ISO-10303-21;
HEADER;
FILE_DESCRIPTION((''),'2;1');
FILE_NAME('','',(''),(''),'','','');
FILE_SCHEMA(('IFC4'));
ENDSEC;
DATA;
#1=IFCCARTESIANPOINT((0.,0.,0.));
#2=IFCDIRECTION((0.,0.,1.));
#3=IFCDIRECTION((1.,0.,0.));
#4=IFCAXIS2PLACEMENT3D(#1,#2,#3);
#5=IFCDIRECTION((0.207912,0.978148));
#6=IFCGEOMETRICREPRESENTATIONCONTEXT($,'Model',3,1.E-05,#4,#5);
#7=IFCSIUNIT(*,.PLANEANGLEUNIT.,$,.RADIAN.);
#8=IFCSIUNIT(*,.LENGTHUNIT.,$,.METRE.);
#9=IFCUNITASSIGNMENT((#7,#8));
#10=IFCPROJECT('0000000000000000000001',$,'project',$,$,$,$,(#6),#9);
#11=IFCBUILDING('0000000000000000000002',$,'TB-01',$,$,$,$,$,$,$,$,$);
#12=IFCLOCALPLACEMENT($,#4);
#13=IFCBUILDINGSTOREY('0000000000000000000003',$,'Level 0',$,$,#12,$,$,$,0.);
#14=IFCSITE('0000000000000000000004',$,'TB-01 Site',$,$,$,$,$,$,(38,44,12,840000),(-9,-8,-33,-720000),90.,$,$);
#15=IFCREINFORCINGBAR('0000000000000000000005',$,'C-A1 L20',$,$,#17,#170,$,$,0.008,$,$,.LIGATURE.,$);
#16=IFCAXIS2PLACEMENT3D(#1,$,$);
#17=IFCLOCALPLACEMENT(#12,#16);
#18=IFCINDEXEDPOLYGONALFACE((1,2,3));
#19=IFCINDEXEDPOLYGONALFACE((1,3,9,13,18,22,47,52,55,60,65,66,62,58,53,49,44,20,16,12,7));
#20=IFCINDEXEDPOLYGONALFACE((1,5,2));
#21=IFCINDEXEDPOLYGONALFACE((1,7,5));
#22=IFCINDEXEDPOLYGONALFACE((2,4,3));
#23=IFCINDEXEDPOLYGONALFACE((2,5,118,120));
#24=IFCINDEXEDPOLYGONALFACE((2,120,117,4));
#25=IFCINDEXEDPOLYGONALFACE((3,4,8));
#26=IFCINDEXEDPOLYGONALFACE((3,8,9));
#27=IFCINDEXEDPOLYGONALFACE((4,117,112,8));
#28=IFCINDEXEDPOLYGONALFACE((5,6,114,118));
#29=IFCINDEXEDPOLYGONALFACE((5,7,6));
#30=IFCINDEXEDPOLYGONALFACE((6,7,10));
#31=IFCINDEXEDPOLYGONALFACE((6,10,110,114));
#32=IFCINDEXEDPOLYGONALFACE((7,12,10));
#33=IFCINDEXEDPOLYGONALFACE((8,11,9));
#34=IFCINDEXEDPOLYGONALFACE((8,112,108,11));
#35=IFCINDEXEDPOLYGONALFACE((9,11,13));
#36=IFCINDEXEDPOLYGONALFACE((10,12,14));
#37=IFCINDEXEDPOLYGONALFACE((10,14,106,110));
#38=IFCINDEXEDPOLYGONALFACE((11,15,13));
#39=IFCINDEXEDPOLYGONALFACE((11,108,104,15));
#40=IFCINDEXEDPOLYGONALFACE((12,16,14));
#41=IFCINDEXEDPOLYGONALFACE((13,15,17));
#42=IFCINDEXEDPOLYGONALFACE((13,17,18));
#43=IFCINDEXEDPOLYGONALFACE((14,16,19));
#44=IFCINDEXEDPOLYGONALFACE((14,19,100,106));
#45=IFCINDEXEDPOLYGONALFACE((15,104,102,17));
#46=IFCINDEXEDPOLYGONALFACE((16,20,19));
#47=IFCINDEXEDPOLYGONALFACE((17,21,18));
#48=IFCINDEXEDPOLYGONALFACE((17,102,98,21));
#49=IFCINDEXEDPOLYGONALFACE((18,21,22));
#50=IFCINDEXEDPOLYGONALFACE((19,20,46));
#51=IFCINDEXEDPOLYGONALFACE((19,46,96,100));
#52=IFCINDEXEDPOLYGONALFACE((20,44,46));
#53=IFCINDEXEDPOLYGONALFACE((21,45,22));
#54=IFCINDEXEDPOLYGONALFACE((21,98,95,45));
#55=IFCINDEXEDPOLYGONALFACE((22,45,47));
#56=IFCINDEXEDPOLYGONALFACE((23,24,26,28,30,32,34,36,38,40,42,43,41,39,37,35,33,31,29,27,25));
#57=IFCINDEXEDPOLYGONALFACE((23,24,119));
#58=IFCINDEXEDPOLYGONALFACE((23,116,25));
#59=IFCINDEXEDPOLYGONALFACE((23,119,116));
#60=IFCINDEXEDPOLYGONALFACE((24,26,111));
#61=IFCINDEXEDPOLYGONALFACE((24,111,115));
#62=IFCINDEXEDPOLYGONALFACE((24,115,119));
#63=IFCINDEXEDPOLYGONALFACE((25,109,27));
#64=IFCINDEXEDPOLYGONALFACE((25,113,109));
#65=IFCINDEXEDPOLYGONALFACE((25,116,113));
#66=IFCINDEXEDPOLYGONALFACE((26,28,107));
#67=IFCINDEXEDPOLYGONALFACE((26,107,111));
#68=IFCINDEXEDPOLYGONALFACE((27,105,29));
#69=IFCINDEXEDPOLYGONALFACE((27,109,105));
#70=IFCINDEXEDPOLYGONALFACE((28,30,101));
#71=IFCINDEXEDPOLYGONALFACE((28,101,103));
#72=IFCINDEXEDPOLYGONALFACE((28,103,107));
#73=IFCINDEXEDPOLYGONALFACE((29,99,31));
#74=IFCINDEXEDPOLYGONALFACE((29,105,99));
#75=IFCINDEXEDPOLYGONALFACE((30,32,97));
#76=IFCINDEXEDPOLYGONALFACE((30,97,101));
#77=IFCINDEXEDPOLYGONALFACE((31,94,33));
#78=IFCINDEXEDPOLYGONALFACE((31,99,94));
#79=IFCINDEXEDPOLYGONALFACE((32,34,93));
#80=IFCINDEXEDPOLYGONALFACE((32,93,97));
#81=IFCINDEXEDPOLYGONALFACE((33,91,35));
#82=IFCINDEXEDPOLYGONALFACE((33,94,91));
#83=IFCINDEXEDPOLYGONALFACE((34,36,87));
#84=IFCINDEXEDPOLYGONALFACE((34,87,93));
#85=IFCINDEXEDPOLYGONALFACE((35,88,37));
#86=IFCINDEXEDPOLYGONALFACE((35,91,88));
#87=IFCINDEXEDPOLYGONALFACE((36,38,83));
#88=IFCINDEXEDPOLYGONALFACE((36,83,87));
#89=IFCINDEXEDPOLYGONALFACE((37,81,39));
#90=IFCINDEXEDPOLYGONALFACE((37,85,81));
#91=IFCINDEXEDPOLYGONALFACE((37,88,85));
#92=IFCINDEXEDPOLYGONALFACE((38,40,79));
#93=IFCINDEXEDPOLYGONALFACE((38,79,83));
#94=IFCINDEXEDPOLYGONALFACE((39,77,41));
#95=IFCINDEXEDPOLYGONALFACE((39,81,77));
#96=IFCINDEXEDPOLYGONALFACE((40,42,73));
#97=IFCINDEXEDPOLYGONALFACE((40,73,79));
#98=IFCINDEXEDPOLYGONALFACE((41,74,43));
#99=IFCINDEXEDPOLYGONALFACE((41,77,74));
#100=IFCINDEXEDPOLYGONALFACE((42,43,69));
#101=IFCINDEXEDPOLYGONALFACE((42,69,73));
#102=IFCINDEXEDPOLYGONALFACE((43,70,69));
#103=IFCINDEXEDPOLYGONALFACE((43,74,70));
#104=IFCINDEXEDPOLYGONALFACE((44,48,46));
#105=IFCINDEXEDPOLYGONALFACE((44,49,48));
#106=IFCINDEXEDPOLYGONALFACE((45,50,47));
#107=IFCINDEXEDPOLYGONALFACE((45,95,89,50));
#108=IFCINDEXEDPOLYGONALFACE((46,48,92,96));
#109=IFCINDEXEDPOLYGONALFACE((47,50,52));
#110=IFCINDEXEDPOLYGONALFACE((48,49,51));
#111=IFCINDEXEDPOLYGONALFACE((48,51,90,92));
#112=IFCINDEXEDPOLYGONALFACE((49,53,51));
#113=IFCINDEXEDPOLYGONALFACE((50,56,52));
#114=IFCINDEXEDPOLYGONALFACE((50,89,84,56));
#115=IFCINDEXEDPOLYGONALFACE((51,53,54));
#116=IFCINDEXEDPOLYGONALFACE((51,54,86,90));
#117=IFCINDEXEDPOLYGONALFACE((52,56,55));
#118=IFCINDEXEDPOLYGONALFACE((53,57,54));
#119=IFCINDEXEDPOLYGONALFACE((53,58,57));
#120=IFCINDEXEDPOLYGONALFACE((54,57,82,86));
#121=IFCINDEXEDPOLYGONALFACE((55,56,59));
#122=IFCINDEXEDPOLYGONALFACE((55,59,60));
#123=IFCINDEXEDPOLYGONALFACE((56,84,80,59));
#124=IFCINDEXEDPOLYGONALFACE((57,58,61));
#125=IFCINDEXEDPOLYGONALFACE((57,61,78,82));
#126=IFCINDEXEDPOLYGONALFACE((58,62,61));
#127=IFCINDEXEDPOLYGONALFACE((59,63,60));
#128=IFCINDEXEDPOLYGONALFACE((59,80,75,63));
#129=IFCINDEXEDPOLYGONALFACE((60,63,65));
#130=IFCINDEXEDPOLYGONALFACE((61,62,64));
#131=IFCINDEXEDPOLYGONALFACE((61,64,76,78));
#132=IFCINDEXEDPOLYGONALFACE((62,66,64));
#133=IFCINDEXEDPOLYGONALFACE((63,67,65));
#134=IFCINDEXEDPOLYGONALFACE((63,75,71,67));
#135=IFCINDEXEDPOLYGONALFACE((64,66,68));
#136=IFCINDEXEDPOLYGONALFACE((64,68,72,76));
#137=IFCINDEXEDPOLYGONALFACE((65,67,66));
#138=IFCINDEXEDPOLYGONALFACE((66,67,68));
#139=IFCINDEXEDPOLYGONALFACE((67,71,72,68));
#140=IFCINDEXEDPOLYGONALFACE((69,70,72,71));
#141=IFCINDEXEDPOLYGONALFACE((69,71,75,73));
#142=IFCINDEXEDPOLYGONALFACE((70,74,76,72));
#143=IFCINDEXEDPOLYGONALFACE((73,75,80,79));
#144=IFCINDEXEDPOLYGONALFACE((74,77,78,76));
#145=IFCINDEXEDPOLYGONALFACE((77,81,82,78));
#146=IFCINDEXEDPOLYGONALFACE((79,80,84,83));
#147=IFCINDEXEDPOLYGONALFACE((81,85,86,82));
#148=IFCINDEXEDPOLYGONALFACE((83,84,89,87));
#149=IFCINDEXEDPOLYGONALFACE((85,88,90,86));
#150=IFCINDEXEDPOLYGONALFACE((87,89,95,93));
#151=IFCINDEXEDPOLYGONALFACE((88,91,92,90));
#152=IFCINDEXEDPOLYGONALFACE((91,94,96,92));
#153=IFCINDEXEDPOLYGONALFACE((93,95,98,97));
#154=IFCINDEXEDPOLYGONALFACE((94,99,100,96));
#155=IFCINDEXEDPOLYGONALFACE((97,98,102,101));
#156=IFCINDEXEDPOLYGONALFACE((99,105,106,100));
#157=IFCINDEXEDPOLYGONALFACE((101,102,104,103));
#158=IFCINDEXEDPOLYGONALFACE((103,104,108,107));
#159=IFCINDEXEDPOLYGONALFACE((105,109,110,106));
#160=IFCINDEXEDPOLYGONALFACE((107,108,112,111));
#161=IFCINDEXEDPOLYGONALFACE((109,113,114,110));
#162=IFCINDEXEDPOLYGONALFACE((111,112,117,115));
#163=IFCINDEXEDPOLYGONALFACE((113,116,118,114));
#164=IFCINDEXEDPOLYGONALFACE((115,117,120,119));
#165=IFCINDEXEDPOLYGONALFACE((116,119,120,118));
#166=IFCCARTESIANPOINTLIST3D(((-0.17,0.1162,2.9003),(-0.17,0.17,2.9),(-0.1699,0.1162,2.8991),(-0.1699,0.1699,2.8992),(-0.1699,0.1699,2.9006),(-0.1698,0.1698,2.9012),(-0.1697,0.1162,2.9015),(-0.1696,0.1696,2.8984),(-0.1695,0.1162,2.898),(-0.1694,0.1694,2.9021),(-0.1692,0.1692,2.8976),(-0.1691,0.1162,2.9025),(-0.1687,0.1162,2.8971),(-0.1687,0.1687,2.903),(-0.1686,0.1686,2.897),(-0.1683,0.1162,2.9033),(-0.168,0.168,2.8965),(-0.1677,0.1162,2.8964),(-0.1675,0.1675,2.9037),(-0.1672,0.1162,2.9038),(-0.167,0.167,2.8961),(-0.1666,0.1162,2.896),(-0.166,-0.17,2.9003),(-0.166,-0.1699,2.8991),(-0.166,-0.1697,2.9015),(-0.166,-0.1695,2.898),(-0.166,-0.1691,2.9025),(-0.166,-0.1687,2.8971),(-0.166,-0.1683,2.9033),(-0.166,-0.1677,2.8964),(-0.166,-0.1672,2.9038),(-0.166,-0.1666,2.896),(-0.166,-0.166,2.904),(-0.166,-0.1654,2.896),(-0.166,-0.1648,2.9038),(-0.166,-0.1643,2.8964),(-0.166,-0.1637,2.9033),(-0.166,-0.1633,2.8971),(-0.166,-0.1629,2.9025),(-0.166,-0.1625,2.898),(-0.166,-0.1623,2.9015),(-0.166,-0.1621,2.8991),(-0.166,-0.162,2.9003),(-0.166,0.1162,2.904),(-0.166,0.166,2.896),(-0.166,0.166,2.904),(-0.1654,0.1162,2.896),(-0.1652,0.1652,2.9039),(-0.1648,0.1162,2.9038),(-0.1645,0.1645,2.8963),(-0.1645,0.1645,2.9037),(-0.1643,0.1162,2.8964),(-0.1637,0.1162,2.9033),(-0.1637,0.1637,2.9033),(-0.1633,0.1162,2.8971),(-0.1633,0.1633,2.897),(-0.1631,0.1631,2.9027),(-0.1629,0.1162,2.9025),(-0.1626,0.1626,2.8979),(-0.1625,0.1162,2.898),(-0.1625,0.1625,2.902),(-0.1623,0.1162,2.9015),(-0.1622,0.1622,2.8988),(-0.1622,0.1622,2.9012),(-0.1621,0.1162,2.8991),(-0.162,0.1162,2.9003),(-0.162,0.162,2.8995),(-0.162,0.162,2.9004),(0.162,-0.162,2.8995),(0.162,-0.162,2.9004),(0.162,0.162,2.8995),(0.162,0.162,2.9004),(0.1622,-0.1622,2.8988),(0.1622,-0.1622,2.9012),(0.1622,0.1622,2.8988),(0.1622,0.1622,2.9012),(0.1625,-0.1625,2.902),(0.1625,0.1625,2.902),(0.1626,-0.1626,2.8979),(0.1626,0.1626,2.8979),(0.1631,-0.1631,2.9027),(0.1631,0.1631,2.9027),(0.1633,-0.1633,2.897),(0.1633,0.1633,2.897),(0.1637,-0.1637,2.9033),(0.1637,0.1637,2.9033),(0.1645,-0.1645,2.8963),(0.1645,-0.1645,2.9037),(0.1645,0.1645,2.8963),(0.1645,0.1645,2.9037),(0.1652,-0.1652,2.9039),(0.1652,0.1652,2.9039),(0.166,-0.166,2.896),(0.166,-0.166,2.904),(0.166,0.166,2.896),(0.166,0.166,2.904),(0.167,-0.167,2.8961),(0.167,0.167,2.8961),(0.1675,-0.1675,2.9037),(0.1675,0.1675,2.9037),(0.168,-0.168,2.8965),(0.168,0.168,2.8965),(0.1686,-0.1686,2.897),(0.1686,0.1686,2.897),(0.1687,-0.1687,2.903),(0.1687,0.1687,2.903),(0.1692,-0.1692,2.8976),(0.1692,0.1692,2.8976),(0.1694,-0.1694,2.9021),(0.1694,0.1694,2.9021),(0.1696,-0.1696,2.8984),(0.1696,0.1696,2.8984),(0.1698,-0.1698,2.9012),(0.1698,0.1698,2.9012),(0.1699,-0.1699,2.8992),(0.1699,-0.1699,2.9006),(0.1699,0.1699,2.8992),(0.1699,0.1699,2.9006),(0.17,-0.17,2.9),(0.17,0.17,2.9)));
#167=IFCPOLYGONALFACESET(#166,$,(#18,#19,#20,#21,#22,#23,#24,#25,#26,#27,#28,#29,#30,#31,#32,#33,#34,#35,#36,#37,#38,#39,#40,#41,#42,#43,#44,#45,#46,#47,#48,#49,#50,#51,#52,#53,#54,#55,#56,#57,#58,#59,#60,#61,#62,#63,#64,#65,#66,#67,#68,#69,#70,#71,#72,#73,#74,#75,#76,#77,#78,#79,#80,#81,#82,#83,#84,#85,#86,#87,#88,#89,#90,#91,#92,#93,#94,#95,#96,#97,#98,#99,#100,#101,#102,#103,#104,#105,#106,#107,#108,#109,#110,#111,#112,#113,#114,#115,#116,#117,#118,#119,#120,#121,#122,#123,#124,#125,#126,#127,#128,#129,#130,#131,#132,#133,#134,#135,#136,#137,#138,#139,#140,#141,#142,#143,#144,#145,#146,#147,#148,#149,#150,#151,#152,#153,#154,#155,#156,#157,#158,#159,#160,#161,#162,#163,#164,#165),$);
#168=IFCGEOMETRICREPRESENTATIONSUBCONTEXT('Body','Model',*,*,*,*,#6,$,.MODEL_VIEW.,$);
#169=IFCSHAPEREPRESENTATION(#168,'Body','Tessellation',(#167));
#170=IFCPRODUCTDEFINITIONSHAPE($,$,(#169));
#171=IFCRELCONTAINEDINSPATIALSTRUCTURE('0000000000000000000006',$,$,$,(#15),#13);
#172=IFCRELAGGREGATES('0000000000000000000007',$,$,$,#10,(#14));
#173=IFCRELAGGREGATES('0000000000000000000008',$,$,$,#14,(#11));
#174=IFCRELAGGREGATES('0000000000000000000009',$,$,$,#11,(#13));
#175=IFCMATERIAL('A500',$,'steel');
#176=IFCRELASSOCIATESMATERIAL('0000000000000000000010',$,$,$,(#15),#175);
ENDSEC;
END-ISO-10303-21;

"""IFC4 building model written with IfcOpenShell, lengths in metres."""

from ifc_helpers import new_model, entity, si_unit, direction, origin_with_axes, place, context, subcontext, project, spatial, material, element, save


model = new_model("IFC4")

# Units and contexts
model_context = context("Model", 3, precision=1e-05, world=origin_with_axes(), true_north=direction((0.207912, 0.978148)))
body_context = subcontext(model_context, "Body", "Model", "MODEL_VIEW")
ifc_project = project(units=[si_unit("PLANEANGLEUNIT", "RADIAN"), si_unit("LENGTHUNIT", "METRE")], contexts=[model_context])

# Site, building, storey
site = spatial("IfcSite", under=ifc_project, Name="TB-01 Site", RefLatitude=(38, 44, 12, 840000), RefLongitude=(-9, -8, -33, -720000), RefElevation=90.0)
building = spatial("IfcBuilding", under=site, Name="TB-01")
storey_placement = place(None, origin_with_axes())
storey = spatial("IfcBuildingStorey", under=building, at=storey_placement, Name="Level 0", Elevation=0.0)

# Reinforcing bar
ifc_material_1 = material(Name="A500", Category="steel")
reinforcing_bar_1_placement = place(storey_placement, origin_with_axes())
element("IfcReinforcingBar", 1, at=reinforcing_bar_1_placement, inside=storey, material=ifc_material_1, Name="C-A1 L20", NominalDiameter=0.008, PredefinedType="LIGATURE", context=body_context, shape_type="AdvancedSweptSolid", body=[
    entity("IfcSweptDiskSolid", entity("IfcPolyline", [entity("IfcCartesianPoint", [-0.166, -0.166, 2.9]), entity("IfcCartesianPoint", [0.166, -0.166, 2.9]), entity("IfcCartesianPoint", [0.166, 0.166, 2.9]), entity("IfcCartesianPoint", [-0.166, 0.166, 2.9]), entity("IfcCartesianPoint", [-0.166, 0.1162, 2.9])]), 0.004),
])

save(model, "model.ifc")
